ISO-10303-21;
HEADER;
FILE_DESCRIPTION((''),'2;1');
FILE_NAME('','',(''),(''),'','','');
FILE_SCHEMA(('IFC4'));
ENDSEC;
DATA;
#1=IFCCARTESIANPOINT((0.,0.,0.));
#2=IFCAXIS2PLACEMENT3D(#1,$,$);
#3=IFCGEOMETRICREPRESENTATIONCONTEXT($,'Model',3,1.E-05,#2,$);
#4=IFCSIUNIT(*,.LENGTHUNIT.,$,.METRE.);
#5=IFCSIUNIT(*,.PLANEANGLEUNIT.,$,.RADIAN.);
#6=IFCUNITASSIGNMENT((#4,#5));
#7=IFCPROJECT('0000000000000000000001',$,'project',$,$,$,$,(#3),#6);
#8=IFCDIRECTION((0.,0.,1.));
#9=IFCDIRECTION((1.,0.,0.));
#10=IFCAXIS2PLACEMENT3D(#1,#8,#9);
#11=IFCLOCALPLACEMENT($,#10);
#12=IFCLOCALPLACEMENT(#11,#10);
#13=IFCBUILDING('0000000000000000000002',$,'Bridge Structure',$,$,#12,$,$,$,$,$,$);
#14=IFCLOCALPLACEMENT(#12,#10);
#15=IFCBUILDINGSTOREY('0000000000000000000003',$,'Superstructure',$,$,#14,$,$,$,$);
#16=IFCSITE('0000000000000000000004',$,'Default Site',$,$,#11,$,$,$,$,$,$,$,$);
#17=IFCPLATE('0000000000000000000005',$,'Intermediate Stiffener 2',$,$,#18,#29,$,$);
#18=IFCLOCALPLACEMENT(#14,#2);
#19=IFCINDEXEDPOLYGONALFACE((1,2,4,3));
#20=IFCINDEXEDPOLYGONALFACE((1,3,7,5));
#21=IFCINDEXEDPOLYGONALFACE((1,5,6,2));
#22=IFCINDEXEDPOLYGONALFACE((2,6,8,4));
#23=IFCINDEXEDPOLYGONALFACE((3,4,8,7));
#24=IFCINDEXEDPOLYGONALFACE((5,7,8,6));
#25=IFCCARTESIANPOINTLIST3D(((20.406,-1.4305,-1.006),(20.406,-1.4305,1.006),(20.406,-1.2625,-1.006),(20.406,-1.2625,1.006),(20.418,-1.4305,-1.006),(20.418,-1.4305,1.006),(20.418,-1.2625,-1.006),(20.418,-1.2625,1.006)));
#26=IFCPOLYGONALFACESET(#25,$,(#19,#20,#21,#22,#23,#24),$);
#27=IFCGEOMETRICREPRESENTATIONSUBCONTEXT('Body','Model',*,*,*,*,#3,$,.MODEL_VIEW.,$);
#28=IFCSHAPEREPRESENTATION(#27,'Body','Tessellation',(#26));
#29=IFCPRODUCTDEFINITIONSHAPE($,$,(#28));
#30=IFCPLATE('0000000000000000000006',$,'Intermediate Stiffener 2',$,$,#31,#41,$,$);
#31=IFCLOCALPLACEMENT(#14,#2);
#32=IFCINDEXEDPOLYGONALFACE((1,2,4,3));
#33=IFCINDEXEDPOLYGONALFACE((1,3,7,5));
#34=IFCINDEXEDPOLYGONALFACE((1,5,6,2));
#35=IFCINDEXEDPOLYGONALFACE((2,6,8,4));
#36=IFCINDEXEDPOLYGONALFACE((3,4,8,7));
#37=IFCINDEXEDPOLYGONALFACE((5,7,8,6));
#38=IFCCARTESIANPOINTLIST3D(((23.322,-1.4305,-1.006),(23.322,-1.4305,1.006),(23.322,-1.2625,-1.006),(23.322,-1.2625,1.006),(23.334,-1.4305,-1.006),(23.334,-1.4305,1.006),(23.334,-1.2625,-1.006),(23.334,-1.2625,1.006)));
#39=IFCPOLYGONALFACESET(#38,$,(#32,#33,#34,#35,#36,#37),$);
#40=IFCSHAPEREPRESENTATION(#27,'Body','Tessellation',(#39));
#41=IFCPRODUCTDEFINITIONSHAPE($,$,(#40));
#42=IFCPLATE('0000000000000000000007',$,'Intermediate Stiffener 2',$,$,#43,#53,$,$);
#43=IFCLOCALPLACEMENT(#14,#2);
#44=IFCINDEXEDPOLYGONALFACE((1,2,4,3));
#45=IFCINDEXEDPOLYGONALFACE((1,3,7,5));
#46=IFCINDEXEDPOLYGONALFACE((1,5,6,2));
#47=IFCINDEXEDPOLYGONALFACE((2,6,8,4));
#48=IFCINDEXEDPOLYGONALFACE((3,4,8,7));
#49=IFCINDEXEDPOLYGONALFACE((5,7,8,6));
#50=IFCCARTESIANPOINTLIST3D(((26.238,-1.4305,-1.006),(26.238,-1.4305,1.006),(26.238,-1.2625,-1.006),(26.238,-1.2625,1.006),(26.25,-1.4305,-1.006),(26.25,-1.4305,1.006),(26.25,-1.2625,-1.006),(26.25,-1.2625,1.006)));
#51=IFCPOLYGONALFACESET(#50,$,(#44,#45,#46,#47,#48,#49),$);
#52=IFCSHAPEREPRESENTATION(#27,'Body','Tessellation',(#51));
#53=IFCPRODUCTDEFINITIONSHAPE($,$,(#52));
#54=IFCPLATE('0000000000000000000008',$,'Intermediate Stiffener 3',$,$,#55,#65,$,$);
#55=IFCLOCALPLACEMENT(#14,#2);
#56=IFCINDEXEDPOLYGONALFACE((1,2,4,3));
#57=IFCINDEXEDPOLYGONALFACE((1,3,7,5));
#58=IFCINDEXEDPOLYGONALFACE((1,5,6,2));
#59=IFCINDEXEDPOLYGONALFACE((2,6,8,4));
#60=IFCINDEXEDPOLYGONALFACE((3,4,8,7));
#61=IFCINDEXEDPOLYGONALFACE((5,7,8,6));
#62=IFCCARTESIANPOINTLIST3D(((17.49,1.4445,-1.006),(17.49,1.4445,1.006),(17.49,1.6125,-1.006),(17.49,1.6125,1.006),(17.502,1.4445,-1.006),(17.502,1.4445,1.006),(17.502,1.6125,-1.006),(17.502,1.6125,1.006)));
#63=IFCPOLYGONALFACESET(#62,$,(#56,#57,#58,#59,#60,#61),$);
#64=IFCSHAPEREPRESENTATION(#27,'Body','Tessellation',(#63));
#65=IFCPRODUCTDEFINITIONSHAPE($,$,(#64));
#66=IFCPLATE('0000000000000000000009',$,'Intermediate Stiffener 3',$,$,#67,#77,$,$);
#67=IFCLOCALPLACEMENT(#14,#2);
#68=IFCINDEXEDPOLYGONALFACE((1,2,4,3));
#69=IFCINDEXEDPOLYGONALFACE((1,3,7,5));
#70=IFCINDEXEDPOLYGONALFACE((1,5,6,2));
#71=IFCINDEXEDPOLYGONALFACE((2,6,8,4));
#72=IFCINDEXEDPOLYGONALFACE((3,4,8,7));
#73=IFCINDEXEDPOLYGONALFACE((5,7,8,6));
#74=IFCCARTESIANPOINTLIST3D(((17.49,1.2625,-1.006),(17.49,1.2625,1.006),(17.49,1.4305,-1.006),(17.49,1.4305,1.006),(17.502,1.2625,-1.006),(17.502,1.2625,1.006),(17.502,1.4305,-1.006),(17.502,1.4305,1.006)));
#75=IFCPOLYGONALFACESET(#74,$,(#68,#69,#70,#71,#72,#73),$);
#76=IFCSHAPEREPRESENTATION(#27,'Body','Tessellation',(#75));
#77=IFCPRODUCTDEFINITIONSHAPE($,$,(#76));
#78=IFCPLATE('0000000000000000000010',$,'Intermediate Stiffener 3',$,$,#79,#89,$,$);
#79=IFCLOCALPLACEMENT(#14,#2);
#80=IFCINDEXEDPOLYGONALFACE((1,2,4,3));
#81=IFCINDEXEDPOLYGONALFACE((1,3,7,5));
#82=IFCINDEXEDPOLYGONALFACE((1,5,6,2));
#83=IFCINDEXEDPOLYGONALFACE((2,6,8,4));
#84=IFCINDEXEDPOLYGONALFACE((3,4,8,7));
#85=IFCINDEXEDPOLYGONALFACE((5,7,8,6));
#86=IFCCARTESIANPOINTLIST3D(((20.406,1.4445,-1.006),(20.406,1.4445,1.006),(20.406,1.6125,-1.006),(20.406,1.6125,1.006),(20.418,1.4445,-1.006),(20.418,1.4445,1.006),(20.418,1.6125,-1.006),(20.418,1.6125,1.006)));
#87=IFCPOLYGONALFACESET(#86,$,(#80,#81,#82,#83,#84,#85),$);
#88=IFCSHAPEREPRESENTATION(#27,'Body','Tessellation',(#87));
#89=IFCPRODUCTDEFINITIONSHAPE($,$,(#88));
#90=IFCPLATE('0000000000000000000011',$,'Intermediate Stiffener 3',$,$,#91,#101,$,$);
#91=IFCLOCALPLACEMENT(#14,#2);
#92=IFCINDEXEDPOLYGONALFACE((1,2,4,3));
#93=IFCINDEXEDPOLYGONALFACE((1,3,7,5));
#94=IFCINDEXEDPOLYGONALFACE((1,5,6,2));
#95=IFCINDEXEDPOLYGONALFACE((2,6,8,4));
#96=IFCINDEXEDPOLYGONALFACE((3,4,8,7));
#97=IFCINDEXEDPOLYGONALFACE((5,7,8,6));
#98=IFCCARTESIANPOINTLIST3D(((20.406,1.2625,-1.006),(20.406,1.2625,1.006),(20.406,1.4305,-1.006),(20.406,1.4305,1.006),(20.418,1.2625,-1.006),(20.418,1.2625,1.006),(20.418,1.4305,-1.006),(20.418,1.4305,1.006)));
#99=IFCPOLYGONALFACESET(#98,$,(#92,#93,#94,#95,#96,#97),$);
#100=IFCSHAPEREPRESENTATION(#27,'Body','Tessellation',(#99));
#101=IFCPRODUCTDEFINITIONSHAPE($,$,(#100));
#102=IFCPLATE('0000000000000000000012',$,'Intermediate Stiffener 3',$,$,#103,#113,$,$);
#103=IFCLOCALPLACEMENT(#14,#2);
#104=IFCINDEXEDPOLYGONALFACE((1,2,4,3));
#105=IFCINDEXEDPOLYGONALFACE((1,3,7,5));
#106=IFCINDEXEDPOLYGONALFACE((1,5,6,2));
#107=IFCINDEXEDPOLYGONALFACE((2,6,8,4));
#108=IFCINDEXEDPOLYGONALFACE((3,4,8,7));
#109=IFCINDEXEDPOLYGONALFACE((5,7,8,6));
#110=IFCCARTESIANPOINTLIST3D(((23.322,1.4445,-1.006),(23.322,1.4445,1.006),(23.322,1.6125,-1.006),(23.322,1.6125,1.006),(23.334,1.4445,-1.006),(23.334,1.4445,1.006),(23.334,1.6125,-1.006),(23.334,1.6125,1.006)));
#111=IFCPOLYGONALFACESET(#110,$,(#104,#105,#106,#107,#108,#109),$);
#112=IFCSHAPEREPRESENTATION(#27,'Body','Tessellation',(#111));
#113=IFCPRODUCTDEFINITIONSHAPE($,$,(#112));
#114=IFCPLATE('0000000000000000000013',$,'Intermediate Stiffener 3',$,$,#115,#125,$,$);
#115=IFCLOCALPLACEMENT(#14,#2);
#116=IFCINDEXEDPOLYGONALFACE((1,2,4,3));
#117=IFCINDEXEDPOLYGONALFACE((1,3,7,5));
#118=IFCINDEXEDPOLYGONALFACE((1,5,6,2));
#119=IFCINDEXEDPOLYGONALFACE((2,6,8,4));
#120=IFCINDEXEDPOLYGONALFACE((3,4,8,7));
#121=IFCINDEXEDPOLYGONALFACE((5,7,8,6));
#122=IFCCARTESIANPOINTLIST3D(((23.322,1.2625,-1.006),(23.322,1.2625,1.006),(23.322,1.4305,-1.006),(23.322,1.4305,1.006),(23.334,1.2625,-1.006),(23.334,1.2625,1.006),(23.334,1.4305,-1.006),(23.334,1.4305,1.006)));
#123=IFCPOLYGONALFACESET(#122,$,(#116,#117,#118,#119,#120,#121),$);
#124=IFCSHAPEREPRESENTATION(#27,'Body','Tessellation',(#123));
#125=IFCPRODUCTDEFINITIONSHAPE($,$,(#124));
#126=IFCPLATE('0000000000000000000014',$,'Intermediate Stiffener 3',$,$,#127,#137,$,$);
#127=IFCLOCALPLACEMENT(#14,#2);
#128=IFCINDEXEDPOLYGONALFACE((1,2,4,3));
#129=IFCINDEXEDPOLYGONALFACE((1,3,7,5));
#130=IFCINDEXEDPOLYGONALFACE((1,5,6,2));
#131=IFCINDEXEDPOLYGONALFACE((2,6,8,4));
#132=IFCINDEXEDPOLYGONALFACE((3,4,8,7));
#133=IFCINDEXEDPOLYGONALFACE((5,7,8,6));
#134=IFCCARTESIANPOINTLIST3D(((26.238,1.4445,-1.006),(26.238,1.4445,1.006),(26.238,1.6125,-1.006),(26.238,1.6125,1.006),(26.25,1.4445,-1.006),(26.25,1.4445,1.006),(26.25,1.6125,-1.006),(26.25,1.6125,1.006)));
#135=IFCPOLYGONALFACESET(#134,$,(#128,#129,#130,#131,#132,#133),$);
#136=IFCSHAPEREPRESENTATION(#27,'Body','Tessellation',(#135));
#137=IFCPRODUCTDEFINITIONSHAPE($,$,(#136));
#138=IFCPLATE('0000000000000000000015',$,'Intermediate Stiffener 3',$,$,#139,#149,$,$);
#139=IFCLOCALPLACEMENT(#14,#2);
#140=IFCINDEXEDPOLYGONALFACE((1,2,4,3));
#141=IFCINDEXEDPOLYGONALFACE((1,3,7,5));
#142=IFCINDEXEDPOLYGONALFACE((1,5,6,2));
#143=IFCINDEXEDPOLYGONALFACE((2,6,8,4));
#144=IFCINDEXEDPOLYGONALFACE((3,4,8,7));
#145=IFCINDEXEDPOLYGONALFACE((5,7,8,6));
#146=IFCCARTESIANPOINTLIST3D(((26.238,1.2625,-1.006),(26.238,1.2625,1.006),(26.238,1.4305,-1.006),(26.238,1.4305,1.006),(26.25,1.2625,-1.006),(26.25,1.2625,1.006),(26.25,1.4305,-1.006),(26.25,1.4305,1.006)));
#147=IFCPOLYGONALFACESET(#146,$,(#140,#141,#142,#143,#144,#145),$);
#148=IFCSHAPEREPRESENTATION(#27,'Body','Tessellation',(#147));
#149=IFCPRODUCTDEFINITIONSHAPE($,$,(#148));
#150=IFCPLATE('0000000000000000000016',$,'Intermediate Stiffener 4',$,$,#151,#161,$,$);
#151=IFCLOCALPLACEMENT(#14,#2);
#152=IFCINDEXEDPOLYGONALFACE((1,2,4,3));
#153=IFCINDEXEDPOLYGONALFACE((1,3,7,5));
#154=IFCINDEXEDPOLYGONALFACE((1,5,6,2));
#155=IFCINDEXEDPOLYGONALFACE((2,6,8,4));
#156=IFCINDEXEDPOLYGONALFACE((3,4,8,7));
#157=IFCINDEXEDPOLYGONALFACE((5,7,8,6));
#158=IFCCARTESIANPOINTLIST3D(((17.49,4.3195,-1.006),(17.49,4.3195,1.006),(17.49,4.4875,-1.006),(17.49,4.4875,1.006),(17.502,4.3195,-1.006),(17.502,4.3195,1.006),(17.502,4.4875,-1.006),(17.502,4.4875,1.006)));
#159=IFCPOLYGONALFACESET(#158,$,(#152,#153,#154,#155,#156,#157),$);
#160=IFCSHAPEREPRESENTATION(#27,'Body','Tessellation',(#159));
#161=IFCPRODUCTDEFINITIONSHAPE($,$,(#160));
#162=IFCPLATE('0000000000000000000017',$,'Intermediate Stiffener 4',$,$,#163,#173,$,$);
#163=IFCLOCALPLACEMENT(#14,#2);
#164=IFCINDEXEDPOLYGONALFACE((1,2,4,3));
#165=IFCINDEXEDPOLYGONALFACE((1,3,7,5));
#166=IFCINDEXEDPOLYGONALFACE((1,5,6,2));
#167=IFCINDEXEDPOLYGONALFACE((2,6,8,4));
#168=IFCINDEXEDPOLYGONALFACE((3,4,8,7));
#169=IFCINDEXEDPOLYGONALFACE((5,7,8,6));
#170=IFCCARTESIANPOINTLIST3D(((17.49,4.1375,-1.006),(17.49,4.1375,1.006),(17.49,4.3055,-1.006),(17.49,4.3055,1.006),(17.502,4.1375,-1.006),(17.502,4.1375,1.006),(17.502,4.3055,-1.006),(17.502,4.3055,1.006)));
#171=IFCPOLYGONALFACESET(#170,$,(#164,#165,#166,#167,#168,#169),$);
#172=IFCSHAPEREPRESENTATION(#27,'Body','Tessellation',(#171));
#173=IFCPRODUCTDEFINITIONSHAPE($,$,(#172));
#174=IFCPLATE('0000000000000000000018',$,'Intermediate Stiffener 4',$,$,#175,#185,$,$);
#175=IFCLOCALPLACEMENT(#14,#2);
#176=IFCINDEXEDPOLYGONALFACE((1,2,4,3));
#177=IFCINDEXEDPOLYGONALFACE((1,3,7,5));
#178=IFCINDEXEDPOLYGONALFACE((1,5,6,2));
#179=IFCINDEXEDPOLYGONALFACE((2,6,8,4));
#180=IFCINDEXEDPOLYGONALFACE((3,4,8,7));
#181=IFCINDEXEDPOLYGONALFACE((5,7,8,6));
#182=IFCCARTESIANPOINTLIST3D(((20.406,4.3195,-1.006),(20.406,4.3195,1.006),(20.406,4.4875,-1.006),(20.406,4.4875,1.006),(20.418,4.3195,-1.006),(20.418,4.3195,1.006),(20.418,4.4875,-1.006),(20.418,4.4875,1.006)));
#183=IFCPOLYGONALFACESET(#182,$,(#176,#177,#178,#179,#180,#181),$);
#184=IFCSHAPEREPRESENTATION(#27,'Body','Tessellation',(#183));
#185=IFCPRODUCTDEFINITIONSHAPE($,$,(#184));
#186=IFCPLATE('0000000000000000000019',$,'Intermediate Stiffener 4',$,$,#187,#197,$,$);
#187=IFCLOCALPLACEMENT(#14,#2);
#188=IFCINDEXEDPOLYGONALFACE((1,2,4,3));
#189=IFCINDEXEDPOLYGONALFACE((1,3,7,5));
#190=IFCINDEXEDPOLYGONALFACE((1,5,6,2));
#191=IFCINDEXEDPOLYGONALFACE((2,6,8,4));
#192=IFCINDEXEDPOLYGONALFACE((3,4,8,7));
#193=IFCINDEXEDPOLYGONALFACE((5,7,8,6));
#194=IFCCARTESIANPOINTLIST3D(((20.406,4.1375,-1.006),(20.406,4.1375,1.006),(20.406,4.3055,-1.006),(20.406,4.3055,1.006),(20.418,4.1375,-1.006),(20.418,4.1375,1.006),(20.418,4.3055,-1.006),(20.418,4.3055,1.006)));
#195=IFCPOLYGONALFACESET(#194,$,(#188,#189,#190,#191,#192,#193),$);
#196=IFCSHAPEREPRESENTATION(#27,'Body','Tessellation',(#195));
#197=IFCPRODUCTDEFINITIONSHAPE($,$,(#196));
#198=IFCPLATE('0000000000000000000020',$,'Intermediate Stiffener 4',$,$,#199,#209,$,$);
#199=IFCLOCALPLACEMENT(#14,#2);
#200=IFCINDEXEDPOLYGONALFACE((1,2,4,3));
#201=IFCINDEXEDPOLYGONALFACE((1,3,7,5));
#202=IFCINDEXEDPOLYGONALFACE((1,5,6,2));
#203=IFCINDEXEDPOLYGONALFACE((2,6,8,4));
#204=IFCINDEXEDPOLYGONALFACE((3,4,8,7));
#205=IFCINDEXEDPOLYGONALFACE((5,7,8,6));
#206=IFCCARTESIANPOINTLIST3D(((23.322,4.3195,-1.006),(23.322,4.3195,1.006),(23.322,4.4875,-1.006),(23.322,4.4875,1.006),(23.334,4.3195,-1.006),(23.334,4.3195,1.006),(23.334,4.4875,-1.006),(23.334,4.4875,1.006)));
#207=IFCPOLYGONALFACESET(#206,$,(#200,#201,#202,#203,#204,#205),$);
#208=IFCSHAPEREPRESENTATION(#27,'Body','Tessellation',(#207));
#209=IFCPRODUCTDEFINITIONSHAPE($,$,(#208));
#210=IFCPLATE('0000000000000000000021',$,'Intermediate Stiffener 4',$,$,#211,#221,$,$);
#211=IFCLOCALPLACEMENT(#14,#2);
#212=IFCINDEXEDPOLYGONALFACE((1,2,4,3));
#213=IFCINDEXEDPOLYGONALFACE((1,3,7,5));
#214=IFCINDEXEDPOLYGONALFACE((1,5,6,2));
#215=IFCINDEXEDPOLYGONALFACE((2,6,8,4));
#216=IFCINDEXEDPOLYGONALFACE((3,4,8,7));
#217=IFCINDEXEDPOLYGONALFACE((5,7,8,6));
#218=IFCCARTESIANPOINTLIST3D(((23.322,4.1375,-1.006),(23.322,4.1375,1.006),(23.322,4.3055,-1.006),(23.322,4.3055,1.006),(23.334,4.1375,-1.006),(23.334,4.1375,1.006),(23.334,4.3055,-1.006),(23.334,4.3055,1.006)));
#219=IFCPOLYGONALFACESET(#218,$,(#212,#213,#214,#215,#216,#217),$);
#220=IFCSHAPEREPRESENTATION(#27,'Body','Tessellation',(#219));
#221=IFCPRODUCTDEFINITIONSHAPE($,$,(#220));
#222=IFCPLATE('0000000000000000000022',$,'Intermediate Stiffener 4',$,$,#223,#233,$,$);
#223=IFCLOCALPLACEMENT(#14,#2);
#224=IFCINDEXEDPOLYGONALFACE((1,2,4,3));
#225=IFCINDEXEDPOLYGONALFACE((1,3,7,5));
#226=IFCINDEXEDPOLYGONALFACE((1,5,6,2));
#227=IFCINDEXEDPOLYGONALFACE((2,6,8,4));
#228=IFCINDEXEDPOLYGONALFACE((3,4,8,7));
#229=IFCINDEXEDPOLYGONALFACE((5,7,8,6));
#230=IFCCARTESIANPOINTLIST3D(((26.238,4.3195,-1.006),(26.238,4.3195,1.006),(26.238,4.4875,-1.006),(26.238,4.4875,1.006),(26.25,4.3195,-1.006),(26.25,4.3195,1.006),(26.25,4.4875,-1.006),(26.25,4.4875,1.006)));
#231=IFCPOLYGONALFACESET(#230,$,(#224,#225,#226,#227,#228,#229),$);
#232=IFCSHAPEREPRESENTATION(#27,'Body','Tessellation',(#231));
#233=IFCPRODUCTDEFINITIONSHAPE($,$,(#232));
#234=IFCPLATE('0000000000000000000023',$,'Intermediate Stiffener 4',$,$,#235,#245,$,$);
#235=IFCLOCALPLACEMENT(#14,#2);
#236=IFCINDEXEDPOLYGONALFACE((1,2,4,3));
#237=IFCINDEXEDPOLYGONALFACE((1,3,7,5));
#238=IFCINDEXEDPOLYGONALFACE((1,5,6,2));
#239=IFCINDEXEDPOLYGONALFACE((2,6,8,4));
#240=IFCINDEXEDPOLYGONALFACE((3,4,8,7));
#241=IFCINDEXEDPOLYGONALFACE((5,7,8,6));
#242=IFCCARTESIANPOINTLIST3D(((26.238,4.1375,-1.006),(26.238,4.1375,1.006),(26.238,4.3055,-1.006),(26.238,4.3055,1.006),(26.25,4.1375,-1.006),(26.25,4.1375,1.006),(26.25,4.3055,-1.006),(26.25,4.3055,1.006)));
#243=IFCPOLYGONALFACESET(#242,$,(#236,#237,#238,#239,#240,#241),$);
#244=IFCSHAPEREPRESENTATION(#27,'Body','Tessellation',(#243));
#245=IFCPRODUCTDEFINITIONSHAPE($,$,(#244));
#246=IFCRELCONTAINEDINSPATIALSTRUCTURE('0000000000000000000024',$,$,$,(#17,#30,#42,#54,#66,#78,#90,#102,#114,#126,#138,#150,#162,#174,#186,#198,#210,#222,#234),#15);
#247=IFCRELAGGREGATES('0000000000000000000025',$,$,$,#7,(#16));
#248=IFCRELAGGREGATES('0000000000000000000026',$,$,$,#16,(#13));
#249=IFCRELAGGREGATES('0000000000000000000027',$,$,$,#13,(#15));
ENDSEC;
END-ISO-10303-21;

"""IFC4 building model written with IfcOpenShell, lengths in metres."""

from ifc_helpers import new_model, si_unit, frame, origin, origin_with_axes, origin_2d_with_axis, place, context, subcontext, project, spatial, rectangle, extrude, element, save


model = new_model("IFC4")

# Units and contexts
model_context = context("Model", 3, precision=1e-05, world=origin())
body_context = subcontext(model_context, "Body", "Model", "MODEL_VIEW")
ifc_project = project(units=[si_unit("LENGTHUNIT", "METRE"), si_unit("PLANEANGLEUNIT", "RADIAN")], contexts=[model_context])

# Site, building, storey
site_placement = place(None, origin_with_axes())
site = spatial("IfcSite", under=ifc_project, at=site_placement, Name="Default Site")
building_placement = place(site_placement, origin_with_axes())
building = spatial("IfcBuilding", under=site, at=building_placement, Name="Bridge Structure")
storey_placement = place(building_placement, origin_with_axes())
storey = spatial("IfcBuildingStorey", under=building, at=storey_placement, Name="Superstructure")

# Plates
for number, where, z_axis, x_axis, name in (
    (1, (20.412, -1.3465, -1.006), (0.0, 0.0, 1.0), (1.0, 0.0, 0.0), "Intermediate Stiffener 2"),
    (2, (23.328, -1.3465, -1.006), (0.0, 0.0, 1.0), (1.0, 0.0, 0.0), "Intermediate Stiffener 2"),
    (3, (26.244, -1.3465, -1.006), (0.0, 0.0, 1.0), (1.0, 0.0, 0.0), "Intermediate Stiffener 2"),
    (4, (17.496, 1.5285, -1.006), (0.0, 0.0, 1.0), (1.0, 0.0, 0.0), "Intermediate Stiffener 3"),
    (5, (17.496, 1.3465, -1.006), (0.0, 0.0, 1.0), (1.0, 0.0, 0.0), "Intermediate Stiffener 3"),
    (6, (20.412, 1.5285, -1.006), (0.0, 0.0, 1.0), (1.0, 0.0, 0.0), "Intermediate Stiffener 3"),
    (7, (20.412, 1.3465, -1.006), (0.0, 0.0, 1.0), (1.0, 0.0, 0.0), "Intermediate Stiffener 3"),
    (8, (23.328, 1.5285, -1.006), (0.0, 0.0, 1.0), (1.0, 0.0, 0.0), "Intermediate Stiffener 3"),
    (9, (23.328, 1.3465, -1.006), (0.0, 0.0, 1.0), (1.0, 0.0, 0.0), "Intermediate Stiffener 3"),
    (10, (26.244, 1.5285, -1.006), (0.0, 0.0, 1.0), (1.0, 0.0, 0.0), "Intermediate Stiffener 3"),
    (11, (26.244, 1.3465, -1.006), (0.0, 0.0, 1.0), (1.0, 0.0, 0.0), "Intermediate Stiffener 3"),
    (12, (17.496, 4.4035, -1.006), (0.0, 0.0, 1.0), (1.0, 0.0, 0.0), "Intermediate Stiffener 4"),
    (13, (17.496, 4.2215, -1.006), (0.0, 0.0, 1.0), (1.0, 0.0, 0.0), "Intermediate Stiffener 4"),
    (14, (20.412, 4.4035, -1.006), (0.0, 0.0, 1.0), (1.0, 0.0, 0.0), "Intermediate Stiffener 4"),
    (15, (20.412, 4.2215, -1.006), (0.0, 0.0, 1.0), (1.0, 0.0, 0.0), "Intermediate Stiffener 4"),
    (16, (23.328, 4.4035, -1.006), (0.0, 0.0, 1.0), (1.0, 0.0, 0.0), "Intermediate Stiffener 4"),
    (17, (23.328, 4.2215, -1.006), (0.0, 0.0, 1.0), (1.0, 0.0, 0.0), "Intermediate Stiffener 4"),
    (18, (26.244, 4.4035, -1.006), (0.0, 0.0, 1.0), (1.0, 0.0, 0.0), "Intermediate Stiffener 4"),
    (19, (26.244, 4.2215, -1.006), (0.0, 0.0, 1.0), (1.0, 0.0, 0.0), "Intermediate Stiffener 4"),
):
    element("IfcPlate", number, at=place(storey_placement, frame(where, z_axis=z_axis, x_axis=x_axis)), inside=storey, Name=name, context=body_context, shape_type="SweptSolid", body=[
        extrude(rectangle(XDim=0.012, YDim=0.168, at=origin_2d_with_axis()), origin_with_axes(), (0.0, 0.0, 1.0), 2.012),
    ])

save(model, "model.ifc")
